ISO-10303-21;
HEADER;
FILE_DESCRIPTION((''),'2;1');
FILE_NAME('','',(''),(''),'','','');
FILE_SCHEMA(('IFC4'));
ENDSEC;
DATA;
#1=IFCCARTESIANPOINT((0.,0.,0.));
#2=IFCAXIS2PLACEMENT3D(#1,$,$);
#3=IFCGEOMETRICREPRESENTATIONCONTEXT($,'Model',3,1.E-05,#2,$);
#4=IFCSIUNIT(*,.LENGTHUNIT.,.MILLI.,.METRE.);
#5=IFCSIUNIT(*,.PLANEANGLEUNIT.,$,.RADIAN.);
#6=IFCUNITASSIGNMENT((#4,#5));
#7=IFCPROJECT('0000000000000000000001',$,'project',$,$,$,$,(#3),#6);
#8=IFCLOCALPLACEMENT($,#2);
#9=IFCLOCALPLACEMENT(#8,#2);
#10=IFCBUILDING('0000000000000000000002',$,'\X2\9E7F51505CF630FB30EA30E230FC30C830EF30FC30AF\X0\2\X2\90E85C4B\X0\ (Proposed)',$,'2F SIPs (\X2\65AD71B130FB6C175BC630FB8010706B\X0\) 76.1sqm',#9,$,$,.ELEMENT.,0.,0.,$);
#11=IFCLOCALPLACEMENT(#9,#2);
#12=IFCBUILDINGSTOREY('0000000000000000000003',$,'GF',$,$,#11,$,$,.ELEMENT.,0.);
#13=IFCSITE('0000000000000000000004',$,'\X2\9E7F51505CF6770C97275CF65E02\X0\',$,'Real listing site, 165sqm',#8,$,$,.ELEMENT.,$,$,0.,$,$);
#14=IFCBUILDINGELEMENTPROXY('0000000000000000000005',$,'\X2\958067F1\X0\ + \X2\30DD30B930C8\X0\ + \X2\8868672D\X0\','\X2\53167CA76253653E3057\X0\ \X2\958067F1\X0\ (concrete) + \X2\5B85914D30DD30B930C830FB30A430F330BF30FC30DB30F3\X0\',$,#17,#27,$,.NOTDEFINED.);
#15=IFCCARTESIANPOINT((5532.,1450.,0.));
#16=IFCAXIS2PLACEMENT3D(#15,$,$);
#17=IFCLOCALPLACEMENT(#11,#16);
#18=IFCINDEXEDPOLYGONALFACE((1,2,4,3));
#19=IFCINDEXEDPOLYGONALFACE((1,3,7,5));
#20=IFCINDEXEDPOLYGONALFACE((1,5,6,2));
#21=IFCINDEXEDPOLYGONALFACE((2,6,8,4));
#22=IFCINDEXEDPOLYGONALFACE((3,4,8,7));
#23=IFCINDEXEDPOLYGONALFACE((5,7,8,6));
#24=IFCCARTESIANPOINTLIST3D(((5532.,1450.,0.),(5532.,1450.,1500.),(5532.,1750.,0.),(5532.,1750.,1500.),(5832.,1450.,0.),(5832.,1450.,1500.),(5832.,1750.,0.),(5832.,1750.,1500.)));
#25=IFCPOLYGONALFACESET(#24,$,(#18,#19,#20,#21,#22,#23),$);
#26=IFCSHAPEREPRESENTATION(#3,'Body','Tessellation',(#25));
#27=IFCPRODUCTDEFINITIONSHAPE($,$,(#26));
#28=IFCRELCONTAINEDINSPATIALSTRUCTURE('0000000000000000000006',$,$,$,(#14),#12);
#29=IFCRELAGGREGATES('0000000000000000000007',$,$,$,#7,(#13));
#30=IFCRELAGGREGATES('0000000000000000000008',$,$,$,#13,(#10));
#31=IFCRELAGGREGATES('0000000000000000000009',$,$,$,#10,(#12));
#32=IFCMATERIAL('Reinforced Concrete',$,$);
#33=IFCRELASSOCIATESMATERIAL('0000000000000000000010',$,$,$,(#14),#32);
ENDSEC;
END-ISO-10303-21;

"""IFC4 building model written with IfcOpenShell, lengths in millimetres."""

from ifc_helpers import new_model, si_unit, frame, frame_2d, origin, place, context, project, spatial, rectangle, extrude, material, element, save


model = new_model("IFC4")

# Units and contexts
model_context = context("Model", 3, precision=1e-05, world=origin())
ifc_project = project(units=[si_unit("LENGTHUNIT", "METRE", prefix="MILLI"), si_unit("PLANEANGLEUNIT", "RADIAN")], contexts=[model_context])

# Site, building, storey
site_placement = place(None, origin())
site = spatial("IfcSite", under=ifc_project, at=site_placement, Name="鹿児島県霧島市", ObjectType="Real listing site, 165sqm", CompositionType="ELEMENT", RefElevation=0.0)
building_placement = place(site_placement, origin())
building = spatial("IfcBuilding", under=site, at=building_placement, Name="鹿児島・リモートワーク2部屋 (Proposed)", ObjectType="2F SIPs (断熱・気密・耐火) 76.1sqm", CompositionType="ELEMENT", ElevationOfRefHeight=0.0, ElevationOfTerrain=0.0)
storey_placement = place(building_placement, origin())
storey = spatial("IfcBuildingStorey", under=building, at=storey_placement, Name="GF", CompositionType="ELEMENT", Elevation=0.0)

# Shared definitions
ifc_material_1 = material(Name="Reinforced Concrete")

# Building element proxy
proxy_placement = place(storey_placement, frame((5532.0, 1450.0, 0.0)))
element("IfcBuildingElementProxy", 1, at=proxy_placement, inside=storey, material=ifc_material_1, Name="門柱 + ポスト + 表札", Description="化粧打放し 門柱 (concrete) + 宅配ポスト・インターホン", PredefinedType="NOTDEFINED", context=model_context, shape_type="SweptSolid", body=[
    extrude(rectangle(XDim=300.0, YDim=300.0, at=frame_2d((150.0, 150.0))), frame((5532.0, 1450.0, 0.0)), (0.0, 0.0, 1.0), 1500.0),
])

save(model, "model.ifc")
